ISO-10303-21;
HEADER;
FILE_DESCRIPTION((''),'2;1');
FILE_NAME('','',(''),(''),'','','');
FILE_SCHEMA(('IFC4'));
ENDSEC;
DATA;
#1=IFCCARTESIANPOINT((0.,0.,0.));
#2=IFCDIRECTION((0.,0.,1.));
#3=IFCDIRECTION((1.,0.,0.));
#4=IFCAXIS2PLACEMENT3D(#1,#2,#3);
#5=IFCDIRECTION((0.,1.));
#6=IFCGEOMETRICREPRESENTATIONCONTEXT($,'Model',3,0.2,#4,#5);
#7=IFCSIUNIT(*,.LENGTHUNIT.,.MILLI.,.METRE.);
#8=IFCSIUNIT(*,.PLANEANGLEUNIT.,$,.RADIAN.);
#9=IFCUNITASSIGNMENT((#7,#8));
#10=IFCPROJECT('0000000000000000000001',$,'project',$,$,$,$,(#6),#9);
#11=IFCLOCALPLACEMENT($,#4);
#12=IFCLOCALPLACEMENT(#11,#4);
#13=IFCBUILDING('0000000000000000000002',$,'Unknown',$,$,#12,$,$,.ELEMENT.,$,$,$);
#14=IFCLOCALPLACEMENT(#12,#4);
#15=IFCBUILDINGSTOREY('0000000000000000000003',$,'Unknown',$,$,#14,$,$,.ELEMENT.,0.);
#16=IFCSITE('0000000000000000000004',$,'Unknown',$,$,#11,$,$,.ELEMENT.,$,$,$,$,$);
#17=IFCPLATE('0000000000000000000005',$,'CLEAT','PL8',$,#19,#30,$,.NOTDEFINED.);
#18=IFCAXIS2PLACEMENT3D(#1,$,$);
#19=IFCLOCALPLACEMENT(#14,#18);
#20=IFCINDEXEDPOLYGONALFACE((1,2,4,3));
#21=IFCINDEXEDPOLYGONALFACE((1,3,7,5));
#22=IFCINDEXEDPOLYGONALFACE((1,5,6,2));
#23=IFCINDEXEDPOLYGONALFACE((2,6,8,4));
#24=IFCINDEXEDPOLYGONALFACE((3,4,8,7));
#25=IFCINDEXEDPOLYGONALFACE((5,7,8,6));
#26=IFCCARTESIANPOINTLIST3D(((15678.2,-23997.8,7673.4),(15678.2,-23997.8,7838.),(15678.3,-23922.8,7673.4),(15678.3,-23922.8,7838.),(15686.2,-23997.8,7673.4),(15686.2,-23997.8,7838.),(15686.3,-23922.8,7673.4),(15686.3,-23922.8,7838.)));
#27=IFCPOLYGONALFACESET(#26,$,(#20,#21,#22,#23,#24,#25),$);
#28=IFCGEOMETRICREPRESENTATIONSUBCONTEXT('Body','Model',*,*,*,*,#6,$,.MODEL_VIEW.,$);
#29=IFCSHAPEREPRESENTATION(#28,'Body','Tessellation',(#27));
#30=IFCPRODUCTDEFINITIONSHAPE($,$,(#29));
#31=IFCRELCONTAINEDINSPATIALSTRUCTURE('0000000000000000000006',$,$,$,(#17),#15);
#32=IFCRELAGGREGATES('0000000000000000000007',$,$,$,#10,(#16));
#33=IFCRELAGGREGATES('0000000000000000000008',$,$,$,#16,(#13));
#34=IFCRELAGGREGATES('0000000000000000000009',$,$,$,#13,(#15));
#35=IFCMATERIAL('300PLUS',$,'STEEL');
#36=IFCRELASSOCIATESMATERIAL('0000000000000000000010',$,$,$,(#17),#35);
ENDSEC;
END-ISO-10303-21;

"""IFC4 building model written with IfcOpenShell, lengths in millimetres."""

from ifc_helpers import new_model, si_unit, direction, frame, origin_with_axes, place, context, subcontext, project, spatial, line, indexed_curve, outline, extrude, material, element, save


model = new_model("IFC4")

# Units and contexts
model_context = context("Model", 3, precision=0.2, world=origin_with_axes(), true_north=direction((0.0, 1.0)))
body_context = subcontext(model_context, "Body", "Model", "MODEL_VIEW")
ifc_project = project(units=[si_unit("LENGTHUNIT", "METRE", prefix="MILLI"), si_unit("PLANEANGLEUNIT", "RADIAN")], contexts=[model_context])

# Site, building, storey
site_placement = place(None, origin_with_axes())
site = spatial("IfcSite", under=ifc_project, at=site_placement, Name="Unknown", CompositionType="ELEMENT")
building_placement = place(site_placement, origin_with_axes())
building = spatial("IfcBuilding", under=site, at=building_placement, Name="Unknown", CompositionType="ELEMENT")
storey_placement = place(building_placement, origin_with_axes())
storey = spatial("IfcBuildingStorey", under=building, at=storey_placement, Name="Unknown", CompositionType="ELEMENT", Elevation=0.0)

# Shared definitions
ifc_material_1 = material(Name="300PLUS", Category="STEEL")

# Plate
plate_1_placement = place(storey_placement, frame((15682.3, -23922.8, 7838.0), z_axis=(0.999999, -0.001333, 0.0), x_axis=(-0.001333, -0.999999, 0.0)))
element("IfcPlate", 1, at=plate_1_placement, inside=storey, material=ifc_material_1, Name="CLEAT", Description="PL8", PredefinedType="NOTDEFINED", context=body_context, shape_type="SolidModel", body=[
    extrude(outline(indexed_curve([(0.0, 0.0), (75.0, 0.0), (75.0, 164.6), (0.0, 164.6)], segments=[line(1, 2, 3, 4, 1)])), frame((0.0, 0.0, 4.0), z_axis=(0.0, 0.0, 1.0), x_axis=(1.0, 0.0, 0.0)), (0.0, 0.0, -1.0), 8.0),
])

save(model, "model.ifc")
